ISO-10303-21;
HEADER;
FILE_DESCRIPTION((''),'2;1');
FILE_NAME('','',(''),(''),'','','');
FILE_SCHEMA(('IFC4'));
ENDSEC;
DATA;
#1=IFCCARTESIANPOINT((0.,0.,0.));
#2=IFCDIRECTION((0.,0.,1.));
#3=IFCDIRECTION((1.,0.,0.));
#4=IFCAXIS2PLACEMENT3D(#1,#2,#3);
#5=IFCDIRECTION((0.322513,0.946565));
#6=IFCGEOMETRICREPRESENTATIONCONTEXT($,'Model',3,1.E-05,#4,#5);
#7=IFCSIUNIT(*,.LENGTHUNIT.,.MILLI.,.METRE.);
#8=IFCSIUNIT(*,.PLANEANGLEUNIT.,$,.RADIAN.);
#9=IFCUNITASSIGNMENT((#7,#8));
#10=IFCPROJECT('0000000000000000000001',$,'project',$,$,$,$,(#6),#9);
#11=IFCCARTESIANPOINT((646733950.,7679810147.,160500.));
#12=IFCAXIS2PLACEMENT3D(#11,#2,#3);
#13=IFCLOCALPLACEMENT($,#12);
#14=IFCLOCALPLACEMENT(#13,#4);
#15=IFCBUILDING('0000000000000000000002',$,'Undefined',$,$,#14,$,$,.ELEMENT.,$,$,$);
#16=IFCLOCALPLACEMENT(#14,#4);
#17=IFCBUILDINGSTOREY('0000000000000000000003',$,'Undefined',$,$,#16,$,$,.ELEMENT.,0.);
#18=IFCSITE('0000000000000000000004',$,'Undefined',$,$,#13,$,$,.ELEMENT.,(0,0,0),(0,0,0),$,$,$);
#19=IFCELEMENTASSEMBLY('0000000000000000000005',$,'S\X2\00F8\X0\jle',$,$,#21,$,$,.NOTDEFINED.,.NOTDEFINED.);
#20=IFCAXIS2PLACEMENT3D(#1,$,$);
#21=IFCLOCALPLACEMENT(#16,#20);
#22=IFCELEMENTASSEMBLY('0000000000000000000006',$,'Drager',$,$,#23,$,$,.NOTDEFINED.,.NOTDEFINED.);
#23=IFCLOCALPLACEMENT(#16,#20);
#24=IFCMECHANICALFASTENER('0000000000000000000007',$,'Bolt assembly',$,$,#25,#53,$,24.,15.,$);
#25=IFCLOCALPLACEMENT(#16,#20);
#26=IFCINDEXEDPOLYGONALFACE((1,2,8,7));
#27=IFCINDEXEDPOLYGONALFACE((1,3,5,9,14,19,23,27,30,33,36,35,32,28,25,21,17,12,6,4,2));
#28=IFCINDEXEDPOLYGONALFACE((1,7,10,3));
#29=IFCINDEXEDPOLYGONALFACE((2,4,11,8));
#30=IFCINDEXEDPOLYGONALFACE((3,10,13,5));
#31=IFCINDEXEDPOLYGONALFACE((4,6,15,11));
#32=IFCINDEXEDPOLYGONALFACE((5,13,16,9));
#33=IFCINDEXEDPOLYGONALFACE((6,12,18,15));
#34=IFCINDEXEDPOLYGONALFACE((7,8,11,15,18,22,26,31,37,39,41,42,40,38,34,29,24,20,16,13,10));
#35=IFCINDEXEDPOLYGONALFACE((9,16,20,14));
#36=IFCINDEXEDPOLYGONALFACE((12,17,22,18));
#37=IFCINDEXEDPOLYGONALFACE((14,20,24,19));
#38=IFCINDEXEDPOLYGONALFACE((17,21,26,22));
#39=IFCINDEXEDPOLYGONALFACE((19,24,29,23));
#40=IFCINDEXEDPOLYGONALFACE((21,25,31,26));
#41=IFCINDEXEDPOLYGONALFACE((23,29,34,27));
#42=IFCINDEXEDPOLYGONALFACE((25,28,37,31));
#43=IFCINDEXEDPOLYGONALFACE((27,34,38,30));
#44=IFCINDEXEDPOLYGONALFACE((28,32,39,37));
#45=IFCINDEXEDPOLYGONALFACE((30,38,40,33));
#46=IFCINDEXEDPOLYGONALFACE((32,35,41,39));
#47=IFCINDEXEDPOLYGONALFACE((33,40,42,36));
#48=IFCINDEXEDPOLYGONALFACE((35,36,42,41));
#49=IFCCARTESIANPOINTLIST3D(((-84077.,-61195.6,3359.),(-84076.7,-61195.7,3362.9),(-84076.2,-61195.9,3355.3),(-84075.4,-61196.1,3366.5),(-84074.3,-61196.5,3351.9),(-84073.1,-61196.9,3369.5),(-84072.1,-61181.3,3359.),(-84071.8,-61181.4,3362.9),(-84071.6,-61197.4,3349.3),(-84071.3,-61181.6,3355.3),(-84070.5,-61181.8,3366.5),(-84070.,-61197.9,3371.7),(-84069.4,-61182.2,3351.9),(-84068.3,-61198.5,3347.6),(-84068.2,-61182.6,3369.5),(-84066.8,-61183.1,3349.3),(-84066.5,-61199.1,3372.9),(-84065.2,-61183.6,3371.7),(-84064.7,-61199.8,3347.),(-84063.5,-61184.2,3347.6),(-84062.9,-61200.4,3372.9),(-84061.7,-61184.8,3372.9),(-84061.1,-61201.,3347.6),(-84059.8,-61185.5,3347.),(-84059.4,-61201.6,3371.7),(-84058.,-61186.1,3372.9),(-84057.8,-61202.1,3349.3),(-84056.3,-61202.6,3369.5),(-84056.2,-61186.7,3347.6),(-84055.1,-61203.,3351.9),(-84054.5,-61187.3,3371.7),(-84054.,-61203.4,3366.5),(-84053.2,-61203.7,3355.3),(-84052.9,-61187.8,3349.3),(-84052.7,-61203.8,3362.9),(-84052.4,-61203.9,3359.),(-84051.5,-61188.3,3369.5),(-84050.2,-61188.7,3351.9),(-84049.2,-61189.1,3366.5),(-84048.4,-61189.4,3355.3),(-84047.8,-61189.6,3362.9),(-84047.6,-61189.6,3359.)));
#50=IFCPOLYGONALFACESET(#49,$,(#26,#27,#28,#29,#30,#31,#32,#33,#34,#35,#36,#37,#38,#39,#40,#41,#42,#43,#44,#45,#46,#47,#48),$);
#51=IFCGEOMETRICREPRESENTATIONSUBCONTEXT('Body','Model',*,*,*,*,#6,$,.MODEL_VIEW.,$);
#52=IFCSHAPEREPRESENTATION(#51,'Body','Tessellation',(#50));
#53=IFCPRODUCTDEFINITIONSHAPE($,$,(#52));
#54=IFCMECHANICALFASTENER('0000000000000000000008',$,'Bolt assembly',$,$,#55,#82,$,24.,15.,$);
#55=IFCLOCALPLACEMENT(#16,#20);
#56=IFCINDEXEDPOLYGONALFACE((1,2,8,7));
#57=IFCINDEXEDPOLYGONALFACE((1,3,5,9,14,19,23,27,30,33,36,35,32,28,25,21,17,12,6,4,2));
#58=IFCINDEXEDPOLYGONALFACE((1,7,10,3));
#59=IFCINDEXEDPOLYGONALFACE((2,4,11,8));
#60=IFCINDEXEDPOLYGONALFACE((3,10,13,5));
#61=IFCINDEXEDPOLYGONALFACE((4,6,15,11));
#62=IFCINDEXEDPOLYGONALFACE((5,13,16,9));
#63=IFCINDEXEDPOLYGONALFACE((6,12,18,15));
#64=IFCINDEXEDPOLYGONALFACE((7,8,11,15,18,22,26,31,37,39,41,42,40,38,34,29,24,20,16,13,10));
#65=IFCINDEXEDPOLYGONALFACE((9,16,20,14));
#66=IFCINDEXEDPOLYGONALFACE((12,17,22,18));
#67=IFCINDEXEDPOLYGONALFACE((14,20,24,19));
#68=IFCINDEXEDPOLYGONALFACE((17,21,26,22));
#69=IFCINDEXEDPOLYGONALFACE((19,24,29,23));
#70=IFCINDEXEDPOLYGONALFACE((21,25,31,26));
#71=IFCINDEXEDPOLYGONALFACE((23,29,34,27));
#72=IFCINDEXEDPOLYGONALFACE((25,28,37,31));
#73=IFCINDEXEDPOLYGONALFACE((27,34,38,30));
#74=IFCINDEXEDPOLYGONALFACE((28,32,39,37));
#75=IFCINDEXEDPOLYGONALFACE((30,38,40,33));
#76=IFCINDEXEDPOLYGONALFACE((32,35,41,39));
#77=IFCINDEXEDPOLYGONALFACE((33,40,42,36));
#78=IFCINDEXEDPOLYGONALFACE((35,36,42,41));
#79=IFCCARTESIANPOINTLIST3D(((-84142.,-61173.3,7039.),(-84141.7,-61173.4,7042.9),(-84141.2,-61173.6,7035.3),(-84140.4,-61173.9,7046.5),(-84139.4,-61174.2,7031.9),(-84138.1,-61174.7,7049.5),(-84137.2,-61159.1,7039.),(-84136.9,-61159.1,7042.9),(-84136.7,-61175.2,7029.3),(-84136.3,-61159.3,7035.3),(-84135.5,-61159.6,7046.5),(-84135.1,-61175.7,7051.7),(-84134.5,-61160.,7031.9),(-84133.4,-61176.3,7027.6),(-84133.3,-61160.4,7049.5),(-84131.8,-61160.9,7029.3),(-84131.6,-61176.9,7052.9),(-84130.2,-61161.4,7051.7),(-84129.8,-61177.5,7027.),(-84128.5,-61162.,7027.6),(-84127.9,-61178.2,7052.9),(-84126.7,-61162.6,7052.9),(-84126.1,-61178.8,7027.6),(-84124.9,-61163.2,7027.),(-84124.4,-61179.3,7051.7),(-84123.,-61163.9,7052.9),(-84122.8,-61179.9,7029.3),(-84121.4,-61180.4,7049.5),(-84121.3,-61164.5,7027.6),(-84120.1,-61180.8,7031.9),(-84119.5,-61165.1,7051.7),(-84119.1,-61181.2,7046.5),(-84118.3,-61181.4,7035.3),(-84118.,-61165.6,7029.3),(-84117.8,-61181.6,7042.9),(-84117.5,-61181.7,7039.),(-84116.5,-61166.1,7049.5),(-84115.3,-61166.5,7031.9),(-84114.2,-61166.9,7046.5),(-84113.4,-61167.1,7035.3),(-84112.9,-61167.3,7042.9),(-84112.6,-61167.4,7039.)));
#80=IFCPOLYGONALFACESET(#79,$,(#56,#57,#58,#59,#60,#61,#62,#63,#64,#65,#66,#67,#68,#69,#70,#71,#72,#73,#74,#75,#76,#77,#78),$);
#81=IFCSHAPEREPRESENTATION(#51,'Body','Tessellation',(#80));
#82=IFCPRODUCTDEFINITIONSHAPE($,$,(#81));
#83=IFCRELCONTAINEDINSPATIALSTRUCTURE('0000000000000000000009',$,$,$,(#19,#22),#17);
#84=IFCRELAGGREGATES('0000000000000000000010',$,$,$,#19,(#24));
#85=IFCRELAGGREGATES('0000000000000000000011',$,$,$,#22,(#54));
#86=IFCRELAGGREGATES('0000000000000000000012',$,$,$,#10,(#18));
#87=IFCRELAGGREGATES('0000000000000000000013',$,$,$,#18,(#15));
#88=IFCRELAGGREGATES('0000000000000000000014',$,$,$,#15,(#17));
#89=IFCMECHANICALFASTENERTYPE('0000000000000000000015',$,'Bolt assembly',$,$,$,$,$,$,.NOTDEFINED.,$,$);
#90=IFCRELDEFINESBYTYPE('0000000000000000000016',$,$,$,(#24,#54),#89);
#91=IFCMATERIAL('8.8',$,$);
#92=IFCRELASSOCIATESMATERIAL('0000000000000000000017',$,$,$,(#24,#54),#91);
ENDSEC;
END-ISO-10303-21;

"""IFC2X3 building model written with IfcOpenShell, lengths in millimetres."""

from ifc_helpers import new_model, si_unit, direction, frame, origin_with_axes, origin_2d_with_axis, place, context, subcontext, project, spatial, circle, extrude, source, transform, mapped, material, type_object, element, aggregate, save


model = new_model("IFC2X3")

# Units and contexts
model_context = context("Model", 3, precision=1e-05, world=origin_with_axes(), true_north=direction((0.322513, 0.946565)))
body_context = subcontext(model_context, "Body", "Model", "MODEL_VIEW")
ifc_project = project(units=[si_unit("LENGTHUNIT", "METRE", prefix="MILLI"), si_unit("PLANEANGLEUNIT", "RADIAN")], contexts=[model_context])

# Site, building, storey
site_placement = place(None, frame((646733950.0, 7679810147.0, 160500.0), z_axis=(0.0, 0.0, 1.0), x_axis=(1.0, 0.0, 0.0)))
site = spatial("IfcSite", under=ifc_project, at=site_placement, Name="Undefined", CompositionType="ELEMENT", RefLatitude=(0, 0, 0), RefLongitude=(0, 0, 0))
building_placement = place(site_placement, origin_with_axes())
building = spatial("IfcBuilding", under=site, at=building_placement, Name="Undefined", CompositionType="ELEMENT")
storey_placement = place(building_placement, origin_with_axes())
storey = spatial("IfcBuildingStorey", under=building, at=storey_placement, Name="Undefined", CompositionType="ELEMENT", Elevation=0.0)

# Element assembly
assembly_1_placement = place(storey_placement, origin_with_axes())
assembly_1 = element("IfcElementAssembly", 1, at=assembly_1_placement, inside=storey, Name="Søjle", AssemblyPlace="NOTDEFINED", PredefinedType="NOTDEFINED")

# Element assembly
assembly_2_placement = place(storey_placement, origin_with_axes())
assembly_2 = element("IfcElementAssembly", 2, at=assembly_2_placement, inside=storey, Name="Drager", AssemblyPlace="NOTDEFINED", PredefinedType="NOTDEFINED")

# Mechanical fasteners
ifc_material_1 = material(Name="8.8")
mechanical_fastener_type = type_object("IfcMechanicalFastenerType", Name="Bolt assembly")
shared_shape_1 = source(origin_with_axes(), body_context, "Body", "SweptSolid", [
    extrude(circle(Radius=13.0, at=origin_2d_with_axis()), frame((0.0, -7.5, 0.0), z_axis=(0.0, 1.0, 0.0), x_axis=(1.0, 0.0, 0.0)), (0.0, 0.0, 1.0), 15.1),
])
mechanical_fastener_1_placement = place(assembly_1_placement, frame((-84062.3, -61192.7, 3360.0), z_axis=(0.946565, -0.322513, 0.0), x_axis=(0.0, 0.0, -1.0)))
mechanical_fastener_1 = element("IfcMechanicalFastener", 3, at=mechanical_fastener_1_placement, type_object=mechanical_fastener_type, material=ifc_material_1, Name="Bolt assembly", NominalDiameter=24.0, NominalLength=15.0, context=body_context, shape_type="MappedRepresentation", body=[
    mapped(shared_shape_1, transform((0.0, 0.0, 0.0))),
])
aggregate(assembly_1, [mechanical_fastener_1])
shared_shape_2 = source(origin_with_axes(), body_context, "Body", "SweptSolid", [
    extrude(circle(Radius=13.0, at=origin_2d_with_axis()), frame((0.0, -7.4, 0.0), z_axis=(0.0, 1.0, 0.0), x_axis=(1.0, 0.0, 0.0)), (0.0, 0.0, 1.0), 15.1),
])
mechanical_fastener_2_placement = place(assembly_2_placement, frame((-84127.4, -61170.5, 7040.0), z_axis=(0.946565, -0.322513, 0.0), x_axis=(0.0, 0.0, -1.0)))
mechanical_fastener_2 = element("IfcMechanicalFastener", 4, at=mechanical_fastener_2_placement, type_object=mechanical_fastener_type, material=ifc_material_1, Name="Bolt assembly", NominalDiameter=24.0, NominalLength=15.0, context=body_context, shape_type="MappedRepresentation", body=[
    mapped(shared_shape_2, transform((0.0, 0.0, 0.0))),
])
aggregate(assembly_2, [mechanical_fastener_2])

save(model, "model.ifc")
